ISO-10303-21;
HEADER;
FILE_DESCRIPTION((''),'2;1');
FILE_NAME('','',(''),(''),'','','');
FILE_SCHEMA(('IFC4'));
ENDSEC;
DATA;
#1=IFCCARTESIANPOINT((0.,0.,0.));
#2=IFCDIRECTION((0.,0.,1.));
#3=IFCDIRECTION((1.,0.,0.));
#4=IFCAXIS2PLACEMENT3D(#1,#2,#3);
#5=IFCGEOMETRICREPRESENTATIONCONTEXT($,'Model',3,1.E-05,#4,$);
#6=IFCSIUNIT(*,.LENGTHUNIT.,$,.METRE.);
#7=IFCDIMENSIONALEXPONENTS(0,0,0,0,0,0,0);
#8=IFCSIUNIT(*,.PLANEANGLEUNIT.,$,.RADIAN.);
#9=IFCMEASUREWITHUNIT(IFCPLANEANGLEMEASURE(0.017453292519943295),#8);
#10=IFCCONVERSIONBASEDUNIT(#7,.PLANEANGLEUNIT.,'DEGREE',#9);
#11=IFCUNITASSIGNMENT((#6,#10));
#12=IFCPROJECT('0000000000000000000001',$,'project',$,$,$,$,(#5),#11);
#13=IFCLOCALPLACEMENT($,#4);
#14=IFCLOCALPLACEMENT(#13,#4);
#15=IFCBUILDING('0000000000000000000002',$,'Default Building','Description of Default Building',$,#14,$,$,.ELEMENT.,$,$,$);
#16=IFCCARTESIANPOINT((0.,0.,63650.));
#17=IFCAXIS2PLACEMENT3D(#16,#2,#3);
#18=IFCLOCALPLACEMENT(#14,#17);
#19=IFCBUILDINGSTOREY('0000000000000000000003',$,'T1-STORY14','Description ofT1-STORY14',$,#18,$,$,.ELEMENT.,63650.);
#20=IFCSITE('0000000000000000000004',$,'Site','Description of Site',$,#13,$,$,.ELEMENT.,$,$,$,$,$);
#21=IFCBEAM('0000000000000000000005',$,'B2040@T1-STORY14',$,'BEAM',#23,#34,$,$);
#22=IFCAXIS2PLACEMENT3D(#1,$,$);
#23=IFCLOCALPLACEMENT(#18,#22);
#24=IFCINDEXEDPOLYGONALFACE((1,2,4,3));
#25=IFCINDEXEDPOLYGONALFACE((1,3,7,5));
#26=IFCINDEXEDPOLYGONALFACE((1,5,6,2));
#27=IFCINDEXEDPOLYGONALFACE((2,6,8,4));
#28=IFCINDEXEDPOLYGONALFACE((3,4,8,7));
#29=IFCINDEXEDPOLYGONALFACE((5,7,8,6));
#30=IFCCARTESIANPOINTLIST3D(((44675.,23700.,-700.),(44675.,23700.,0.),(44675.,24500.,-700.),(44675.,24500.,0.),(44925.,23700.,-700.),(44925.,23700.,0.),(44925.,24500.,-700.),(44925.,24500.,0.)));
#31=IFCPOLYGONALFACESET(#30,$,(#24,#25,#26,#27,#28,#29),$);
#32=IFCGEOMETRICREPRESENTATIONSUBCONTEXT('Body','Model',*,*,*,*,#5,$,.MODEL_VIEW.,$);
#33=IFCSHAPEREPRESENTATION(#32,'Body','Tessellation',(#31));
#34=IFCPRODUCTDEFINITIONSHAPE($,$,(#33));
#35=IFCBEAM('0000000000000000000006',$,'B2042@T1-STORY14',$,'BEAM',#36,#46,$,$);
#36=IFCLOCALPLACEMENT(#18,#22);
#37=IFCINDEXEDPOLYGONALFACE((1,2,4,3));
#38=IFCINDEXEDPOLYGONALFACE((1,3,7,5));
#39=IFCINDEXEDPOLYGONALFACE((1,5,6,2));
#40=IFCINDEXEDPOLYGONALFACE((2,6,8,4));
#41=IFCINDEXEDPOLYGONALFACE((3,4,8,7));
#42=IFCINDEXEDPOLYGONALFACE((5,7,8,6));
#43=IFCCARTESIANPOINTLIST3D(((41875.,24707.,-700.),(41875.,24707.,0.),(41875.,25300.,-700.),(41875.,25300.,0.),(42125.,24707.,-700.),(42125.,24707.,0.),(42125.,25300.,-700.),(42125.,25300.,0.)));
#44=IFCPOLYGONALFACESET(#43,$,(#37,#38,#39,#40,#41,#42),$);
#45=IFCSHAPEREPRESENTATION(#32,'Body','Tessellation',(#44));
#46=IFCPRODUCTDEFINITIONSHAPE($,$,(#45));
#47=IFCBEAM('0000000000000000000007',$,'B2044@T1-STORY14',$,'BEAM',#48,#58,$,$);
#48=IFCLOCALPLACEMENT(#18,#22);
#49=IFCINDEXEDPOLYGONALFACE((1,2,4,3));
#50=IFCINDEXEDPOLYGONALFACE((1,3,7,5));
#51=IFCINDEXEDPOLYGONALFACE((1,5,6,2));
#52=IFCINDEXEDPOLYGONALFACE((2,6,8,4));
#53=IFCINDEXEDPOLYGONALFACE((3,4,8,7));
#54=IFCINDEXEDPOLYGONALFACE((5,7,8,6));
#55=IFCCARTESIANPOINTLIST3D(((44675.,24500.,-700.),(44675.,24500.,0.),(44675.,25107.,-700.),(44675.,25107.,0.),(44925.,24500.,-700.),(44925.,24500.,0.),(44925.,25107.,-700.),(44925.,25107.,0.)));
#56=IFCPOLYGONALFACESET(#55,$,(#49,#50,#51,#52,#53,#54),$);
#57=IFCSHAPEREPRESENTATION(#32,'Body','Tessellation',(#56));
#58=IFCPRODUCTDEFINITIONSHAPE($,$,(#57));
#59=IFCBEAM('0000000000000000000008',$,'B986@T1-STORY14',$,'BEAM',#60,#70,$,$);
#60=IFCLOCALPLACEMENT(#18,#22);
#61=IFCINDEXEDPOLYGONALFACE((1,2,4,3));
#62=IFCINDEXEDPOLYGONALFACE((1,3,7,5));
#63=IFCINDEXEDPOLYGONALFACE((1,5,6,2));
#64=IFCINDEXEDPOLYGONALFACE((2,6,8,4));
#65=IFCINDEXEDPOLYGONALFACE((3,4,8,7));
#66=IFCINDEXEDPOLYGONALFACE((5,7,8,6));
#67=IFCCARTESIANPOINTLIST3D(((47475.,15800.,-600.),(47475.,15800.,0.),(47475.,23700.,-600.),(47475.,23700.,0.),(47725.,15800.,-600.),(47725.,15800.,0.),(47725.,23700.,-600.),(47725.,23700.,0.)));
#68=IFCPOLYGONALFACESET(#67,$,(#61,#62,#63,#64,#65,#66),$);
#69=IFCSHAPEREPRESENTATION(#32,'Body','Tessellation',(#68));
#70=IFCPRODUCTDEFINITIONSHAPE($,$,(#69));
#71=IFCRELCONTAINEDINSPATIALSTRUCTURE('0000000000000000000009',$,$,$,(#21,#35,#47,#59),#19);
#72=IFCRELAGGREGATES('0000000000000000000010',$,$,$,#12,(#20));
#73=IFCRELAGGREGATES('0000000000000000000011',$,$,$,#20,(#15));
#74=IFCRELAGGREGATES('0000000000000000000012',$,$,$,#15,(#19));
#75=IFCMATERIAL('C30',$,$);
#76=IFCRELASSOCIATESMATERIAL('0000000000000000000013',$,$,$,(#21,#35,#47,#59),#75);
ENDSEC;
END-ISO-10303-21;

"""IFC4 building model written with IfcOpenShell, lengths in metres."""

from ifc_helpers import new_model, entity, si_unit, converted_unit, frame, origin_with_axes, place, context, subcontext, project, spatial, rectangle, extrude, material, element, save


model = new_model("IFC4")

# Units and contexts
model_context = context("Model", 3, precision=1e-05, world=origin_with_axes())
body_context = subcontext(model_context, "Body", "Model", "MODEL_VIEW")
ifc_project = project(units=[si_unit("LENGTHUNIT", "METRE"), converted_unit("PLANEANGLEUNIT", "DEGREE", entity("IfcPlaneAngleMeasure", 0.017453292519943295), si_unit("PLANEANGLEUNIT", "RADIAN"), dimensions=[0, 0, 0, 0, 0, 0, 0])], contexts=[model_context])

# Site, building, storey
site_placement = place(None, origin_with_axes())
site = spatial("IfcSite", under=ifc_project, at=site_placement, Name="Site", Description="Description of Site", CompositionType="ELEMENT")
building_placement = place(site_placement, origin_with_axes())
building = spatial("IfcBuilding", under=site, at=building_placement, Name="Default Building", Description="Description of Default Building", CompositionType="ELEMENT")
storey_placement = place(building_placement, frame((0.0, 0.0, 63650.0), z_axis=(0.0, 0.0, 1.0), x_axis=(1.0, 0.0, 0.0)))
storey = spatial("IfcBuildingStorey", under=building, at=storey_placement, Name="T1-STORY14", Description="Description ofT1-STORY14", CompositionType="ELEMENT", Elevation=63650.0)

# Beams
ifc_material_1 = material(Name="C30")
beam_1_placement = place(storey_placement, frame((44800.0, 23700.0, -350.0), z_axis=(0.0, 1.0, 0.0), x_axis=(-1.0, 0.0, 0.0)))
element("IfcBeam", 1, at=beam_1_placement, inside=storey, material=ifc_material_1, Name="B2040@T1-STORY14", ObjectType="BEAM", context=body_context, shape_type="SweptSolid", body=[
    extrude(rectangle(XDim=250.0, YDim=700.0), origin_with_axes(), (0.0, 0.0, 1.0), 800.0),
])
beam_2_placement = place(storey_placement, frame((42000.0, 24707.0, -350.0), z_axis=(0.0, 1.0, 0.0), x_axis=(-1.0, 0.0, 0.0)))
element("IfcBeam", 2, at=beam_2_placement, inside=storey, material=ifc_material_1, Name="B2042@T1-STORY14", ObjectType="BEAM", context=body_context, shape_type="SweptSolid", body=[
    extrude(rectangle(XDim=250.0, YDim=700.0), origin_with_axes(), (0.0, 0.0, 1.0), 593.0),
])
beam_3_placement = place(storey_placement, frame((44800.0, 24500.0, -350.0), z_axis=(0.0, 1.0, 0.0), x_axis=(-1.0, 0.0, 0.0)))
element("IfcBeam", 3, at=beam_3_placement, inside=storey, material=ifc_material_1, Name="B2044@T1-STORY14", ObjectType="BEAM", context=body_context, shape_type="SweptSolid", body=[
    extrude(rectangle(XDim=250.0, YDim=700.0), origin_with_axes(), (0.0, 0.0, 1.0), 607.0),
])
beam_4_placement = place(storey_placement, frame((47600.0, 15800.0, -300.0), z_axis=(0.0, 1.0, 0.0), x_axis=(-1.0, 0.0, 0.0)))
element("IfcBeam", 4, at=beam_4_placement, inside=storey, material=ifc_material_1, Name="B986@T1-STORY14", ObjectType="BEAM", context=body_context, shape_type="SweptSolid", body=[
    extrude(rectangle(XDim=250.0, YDim=600.0), origin_with_axes(), (0.0, 0.0, 1.0), 7900.0),
])

save(model, "model.ifc")
